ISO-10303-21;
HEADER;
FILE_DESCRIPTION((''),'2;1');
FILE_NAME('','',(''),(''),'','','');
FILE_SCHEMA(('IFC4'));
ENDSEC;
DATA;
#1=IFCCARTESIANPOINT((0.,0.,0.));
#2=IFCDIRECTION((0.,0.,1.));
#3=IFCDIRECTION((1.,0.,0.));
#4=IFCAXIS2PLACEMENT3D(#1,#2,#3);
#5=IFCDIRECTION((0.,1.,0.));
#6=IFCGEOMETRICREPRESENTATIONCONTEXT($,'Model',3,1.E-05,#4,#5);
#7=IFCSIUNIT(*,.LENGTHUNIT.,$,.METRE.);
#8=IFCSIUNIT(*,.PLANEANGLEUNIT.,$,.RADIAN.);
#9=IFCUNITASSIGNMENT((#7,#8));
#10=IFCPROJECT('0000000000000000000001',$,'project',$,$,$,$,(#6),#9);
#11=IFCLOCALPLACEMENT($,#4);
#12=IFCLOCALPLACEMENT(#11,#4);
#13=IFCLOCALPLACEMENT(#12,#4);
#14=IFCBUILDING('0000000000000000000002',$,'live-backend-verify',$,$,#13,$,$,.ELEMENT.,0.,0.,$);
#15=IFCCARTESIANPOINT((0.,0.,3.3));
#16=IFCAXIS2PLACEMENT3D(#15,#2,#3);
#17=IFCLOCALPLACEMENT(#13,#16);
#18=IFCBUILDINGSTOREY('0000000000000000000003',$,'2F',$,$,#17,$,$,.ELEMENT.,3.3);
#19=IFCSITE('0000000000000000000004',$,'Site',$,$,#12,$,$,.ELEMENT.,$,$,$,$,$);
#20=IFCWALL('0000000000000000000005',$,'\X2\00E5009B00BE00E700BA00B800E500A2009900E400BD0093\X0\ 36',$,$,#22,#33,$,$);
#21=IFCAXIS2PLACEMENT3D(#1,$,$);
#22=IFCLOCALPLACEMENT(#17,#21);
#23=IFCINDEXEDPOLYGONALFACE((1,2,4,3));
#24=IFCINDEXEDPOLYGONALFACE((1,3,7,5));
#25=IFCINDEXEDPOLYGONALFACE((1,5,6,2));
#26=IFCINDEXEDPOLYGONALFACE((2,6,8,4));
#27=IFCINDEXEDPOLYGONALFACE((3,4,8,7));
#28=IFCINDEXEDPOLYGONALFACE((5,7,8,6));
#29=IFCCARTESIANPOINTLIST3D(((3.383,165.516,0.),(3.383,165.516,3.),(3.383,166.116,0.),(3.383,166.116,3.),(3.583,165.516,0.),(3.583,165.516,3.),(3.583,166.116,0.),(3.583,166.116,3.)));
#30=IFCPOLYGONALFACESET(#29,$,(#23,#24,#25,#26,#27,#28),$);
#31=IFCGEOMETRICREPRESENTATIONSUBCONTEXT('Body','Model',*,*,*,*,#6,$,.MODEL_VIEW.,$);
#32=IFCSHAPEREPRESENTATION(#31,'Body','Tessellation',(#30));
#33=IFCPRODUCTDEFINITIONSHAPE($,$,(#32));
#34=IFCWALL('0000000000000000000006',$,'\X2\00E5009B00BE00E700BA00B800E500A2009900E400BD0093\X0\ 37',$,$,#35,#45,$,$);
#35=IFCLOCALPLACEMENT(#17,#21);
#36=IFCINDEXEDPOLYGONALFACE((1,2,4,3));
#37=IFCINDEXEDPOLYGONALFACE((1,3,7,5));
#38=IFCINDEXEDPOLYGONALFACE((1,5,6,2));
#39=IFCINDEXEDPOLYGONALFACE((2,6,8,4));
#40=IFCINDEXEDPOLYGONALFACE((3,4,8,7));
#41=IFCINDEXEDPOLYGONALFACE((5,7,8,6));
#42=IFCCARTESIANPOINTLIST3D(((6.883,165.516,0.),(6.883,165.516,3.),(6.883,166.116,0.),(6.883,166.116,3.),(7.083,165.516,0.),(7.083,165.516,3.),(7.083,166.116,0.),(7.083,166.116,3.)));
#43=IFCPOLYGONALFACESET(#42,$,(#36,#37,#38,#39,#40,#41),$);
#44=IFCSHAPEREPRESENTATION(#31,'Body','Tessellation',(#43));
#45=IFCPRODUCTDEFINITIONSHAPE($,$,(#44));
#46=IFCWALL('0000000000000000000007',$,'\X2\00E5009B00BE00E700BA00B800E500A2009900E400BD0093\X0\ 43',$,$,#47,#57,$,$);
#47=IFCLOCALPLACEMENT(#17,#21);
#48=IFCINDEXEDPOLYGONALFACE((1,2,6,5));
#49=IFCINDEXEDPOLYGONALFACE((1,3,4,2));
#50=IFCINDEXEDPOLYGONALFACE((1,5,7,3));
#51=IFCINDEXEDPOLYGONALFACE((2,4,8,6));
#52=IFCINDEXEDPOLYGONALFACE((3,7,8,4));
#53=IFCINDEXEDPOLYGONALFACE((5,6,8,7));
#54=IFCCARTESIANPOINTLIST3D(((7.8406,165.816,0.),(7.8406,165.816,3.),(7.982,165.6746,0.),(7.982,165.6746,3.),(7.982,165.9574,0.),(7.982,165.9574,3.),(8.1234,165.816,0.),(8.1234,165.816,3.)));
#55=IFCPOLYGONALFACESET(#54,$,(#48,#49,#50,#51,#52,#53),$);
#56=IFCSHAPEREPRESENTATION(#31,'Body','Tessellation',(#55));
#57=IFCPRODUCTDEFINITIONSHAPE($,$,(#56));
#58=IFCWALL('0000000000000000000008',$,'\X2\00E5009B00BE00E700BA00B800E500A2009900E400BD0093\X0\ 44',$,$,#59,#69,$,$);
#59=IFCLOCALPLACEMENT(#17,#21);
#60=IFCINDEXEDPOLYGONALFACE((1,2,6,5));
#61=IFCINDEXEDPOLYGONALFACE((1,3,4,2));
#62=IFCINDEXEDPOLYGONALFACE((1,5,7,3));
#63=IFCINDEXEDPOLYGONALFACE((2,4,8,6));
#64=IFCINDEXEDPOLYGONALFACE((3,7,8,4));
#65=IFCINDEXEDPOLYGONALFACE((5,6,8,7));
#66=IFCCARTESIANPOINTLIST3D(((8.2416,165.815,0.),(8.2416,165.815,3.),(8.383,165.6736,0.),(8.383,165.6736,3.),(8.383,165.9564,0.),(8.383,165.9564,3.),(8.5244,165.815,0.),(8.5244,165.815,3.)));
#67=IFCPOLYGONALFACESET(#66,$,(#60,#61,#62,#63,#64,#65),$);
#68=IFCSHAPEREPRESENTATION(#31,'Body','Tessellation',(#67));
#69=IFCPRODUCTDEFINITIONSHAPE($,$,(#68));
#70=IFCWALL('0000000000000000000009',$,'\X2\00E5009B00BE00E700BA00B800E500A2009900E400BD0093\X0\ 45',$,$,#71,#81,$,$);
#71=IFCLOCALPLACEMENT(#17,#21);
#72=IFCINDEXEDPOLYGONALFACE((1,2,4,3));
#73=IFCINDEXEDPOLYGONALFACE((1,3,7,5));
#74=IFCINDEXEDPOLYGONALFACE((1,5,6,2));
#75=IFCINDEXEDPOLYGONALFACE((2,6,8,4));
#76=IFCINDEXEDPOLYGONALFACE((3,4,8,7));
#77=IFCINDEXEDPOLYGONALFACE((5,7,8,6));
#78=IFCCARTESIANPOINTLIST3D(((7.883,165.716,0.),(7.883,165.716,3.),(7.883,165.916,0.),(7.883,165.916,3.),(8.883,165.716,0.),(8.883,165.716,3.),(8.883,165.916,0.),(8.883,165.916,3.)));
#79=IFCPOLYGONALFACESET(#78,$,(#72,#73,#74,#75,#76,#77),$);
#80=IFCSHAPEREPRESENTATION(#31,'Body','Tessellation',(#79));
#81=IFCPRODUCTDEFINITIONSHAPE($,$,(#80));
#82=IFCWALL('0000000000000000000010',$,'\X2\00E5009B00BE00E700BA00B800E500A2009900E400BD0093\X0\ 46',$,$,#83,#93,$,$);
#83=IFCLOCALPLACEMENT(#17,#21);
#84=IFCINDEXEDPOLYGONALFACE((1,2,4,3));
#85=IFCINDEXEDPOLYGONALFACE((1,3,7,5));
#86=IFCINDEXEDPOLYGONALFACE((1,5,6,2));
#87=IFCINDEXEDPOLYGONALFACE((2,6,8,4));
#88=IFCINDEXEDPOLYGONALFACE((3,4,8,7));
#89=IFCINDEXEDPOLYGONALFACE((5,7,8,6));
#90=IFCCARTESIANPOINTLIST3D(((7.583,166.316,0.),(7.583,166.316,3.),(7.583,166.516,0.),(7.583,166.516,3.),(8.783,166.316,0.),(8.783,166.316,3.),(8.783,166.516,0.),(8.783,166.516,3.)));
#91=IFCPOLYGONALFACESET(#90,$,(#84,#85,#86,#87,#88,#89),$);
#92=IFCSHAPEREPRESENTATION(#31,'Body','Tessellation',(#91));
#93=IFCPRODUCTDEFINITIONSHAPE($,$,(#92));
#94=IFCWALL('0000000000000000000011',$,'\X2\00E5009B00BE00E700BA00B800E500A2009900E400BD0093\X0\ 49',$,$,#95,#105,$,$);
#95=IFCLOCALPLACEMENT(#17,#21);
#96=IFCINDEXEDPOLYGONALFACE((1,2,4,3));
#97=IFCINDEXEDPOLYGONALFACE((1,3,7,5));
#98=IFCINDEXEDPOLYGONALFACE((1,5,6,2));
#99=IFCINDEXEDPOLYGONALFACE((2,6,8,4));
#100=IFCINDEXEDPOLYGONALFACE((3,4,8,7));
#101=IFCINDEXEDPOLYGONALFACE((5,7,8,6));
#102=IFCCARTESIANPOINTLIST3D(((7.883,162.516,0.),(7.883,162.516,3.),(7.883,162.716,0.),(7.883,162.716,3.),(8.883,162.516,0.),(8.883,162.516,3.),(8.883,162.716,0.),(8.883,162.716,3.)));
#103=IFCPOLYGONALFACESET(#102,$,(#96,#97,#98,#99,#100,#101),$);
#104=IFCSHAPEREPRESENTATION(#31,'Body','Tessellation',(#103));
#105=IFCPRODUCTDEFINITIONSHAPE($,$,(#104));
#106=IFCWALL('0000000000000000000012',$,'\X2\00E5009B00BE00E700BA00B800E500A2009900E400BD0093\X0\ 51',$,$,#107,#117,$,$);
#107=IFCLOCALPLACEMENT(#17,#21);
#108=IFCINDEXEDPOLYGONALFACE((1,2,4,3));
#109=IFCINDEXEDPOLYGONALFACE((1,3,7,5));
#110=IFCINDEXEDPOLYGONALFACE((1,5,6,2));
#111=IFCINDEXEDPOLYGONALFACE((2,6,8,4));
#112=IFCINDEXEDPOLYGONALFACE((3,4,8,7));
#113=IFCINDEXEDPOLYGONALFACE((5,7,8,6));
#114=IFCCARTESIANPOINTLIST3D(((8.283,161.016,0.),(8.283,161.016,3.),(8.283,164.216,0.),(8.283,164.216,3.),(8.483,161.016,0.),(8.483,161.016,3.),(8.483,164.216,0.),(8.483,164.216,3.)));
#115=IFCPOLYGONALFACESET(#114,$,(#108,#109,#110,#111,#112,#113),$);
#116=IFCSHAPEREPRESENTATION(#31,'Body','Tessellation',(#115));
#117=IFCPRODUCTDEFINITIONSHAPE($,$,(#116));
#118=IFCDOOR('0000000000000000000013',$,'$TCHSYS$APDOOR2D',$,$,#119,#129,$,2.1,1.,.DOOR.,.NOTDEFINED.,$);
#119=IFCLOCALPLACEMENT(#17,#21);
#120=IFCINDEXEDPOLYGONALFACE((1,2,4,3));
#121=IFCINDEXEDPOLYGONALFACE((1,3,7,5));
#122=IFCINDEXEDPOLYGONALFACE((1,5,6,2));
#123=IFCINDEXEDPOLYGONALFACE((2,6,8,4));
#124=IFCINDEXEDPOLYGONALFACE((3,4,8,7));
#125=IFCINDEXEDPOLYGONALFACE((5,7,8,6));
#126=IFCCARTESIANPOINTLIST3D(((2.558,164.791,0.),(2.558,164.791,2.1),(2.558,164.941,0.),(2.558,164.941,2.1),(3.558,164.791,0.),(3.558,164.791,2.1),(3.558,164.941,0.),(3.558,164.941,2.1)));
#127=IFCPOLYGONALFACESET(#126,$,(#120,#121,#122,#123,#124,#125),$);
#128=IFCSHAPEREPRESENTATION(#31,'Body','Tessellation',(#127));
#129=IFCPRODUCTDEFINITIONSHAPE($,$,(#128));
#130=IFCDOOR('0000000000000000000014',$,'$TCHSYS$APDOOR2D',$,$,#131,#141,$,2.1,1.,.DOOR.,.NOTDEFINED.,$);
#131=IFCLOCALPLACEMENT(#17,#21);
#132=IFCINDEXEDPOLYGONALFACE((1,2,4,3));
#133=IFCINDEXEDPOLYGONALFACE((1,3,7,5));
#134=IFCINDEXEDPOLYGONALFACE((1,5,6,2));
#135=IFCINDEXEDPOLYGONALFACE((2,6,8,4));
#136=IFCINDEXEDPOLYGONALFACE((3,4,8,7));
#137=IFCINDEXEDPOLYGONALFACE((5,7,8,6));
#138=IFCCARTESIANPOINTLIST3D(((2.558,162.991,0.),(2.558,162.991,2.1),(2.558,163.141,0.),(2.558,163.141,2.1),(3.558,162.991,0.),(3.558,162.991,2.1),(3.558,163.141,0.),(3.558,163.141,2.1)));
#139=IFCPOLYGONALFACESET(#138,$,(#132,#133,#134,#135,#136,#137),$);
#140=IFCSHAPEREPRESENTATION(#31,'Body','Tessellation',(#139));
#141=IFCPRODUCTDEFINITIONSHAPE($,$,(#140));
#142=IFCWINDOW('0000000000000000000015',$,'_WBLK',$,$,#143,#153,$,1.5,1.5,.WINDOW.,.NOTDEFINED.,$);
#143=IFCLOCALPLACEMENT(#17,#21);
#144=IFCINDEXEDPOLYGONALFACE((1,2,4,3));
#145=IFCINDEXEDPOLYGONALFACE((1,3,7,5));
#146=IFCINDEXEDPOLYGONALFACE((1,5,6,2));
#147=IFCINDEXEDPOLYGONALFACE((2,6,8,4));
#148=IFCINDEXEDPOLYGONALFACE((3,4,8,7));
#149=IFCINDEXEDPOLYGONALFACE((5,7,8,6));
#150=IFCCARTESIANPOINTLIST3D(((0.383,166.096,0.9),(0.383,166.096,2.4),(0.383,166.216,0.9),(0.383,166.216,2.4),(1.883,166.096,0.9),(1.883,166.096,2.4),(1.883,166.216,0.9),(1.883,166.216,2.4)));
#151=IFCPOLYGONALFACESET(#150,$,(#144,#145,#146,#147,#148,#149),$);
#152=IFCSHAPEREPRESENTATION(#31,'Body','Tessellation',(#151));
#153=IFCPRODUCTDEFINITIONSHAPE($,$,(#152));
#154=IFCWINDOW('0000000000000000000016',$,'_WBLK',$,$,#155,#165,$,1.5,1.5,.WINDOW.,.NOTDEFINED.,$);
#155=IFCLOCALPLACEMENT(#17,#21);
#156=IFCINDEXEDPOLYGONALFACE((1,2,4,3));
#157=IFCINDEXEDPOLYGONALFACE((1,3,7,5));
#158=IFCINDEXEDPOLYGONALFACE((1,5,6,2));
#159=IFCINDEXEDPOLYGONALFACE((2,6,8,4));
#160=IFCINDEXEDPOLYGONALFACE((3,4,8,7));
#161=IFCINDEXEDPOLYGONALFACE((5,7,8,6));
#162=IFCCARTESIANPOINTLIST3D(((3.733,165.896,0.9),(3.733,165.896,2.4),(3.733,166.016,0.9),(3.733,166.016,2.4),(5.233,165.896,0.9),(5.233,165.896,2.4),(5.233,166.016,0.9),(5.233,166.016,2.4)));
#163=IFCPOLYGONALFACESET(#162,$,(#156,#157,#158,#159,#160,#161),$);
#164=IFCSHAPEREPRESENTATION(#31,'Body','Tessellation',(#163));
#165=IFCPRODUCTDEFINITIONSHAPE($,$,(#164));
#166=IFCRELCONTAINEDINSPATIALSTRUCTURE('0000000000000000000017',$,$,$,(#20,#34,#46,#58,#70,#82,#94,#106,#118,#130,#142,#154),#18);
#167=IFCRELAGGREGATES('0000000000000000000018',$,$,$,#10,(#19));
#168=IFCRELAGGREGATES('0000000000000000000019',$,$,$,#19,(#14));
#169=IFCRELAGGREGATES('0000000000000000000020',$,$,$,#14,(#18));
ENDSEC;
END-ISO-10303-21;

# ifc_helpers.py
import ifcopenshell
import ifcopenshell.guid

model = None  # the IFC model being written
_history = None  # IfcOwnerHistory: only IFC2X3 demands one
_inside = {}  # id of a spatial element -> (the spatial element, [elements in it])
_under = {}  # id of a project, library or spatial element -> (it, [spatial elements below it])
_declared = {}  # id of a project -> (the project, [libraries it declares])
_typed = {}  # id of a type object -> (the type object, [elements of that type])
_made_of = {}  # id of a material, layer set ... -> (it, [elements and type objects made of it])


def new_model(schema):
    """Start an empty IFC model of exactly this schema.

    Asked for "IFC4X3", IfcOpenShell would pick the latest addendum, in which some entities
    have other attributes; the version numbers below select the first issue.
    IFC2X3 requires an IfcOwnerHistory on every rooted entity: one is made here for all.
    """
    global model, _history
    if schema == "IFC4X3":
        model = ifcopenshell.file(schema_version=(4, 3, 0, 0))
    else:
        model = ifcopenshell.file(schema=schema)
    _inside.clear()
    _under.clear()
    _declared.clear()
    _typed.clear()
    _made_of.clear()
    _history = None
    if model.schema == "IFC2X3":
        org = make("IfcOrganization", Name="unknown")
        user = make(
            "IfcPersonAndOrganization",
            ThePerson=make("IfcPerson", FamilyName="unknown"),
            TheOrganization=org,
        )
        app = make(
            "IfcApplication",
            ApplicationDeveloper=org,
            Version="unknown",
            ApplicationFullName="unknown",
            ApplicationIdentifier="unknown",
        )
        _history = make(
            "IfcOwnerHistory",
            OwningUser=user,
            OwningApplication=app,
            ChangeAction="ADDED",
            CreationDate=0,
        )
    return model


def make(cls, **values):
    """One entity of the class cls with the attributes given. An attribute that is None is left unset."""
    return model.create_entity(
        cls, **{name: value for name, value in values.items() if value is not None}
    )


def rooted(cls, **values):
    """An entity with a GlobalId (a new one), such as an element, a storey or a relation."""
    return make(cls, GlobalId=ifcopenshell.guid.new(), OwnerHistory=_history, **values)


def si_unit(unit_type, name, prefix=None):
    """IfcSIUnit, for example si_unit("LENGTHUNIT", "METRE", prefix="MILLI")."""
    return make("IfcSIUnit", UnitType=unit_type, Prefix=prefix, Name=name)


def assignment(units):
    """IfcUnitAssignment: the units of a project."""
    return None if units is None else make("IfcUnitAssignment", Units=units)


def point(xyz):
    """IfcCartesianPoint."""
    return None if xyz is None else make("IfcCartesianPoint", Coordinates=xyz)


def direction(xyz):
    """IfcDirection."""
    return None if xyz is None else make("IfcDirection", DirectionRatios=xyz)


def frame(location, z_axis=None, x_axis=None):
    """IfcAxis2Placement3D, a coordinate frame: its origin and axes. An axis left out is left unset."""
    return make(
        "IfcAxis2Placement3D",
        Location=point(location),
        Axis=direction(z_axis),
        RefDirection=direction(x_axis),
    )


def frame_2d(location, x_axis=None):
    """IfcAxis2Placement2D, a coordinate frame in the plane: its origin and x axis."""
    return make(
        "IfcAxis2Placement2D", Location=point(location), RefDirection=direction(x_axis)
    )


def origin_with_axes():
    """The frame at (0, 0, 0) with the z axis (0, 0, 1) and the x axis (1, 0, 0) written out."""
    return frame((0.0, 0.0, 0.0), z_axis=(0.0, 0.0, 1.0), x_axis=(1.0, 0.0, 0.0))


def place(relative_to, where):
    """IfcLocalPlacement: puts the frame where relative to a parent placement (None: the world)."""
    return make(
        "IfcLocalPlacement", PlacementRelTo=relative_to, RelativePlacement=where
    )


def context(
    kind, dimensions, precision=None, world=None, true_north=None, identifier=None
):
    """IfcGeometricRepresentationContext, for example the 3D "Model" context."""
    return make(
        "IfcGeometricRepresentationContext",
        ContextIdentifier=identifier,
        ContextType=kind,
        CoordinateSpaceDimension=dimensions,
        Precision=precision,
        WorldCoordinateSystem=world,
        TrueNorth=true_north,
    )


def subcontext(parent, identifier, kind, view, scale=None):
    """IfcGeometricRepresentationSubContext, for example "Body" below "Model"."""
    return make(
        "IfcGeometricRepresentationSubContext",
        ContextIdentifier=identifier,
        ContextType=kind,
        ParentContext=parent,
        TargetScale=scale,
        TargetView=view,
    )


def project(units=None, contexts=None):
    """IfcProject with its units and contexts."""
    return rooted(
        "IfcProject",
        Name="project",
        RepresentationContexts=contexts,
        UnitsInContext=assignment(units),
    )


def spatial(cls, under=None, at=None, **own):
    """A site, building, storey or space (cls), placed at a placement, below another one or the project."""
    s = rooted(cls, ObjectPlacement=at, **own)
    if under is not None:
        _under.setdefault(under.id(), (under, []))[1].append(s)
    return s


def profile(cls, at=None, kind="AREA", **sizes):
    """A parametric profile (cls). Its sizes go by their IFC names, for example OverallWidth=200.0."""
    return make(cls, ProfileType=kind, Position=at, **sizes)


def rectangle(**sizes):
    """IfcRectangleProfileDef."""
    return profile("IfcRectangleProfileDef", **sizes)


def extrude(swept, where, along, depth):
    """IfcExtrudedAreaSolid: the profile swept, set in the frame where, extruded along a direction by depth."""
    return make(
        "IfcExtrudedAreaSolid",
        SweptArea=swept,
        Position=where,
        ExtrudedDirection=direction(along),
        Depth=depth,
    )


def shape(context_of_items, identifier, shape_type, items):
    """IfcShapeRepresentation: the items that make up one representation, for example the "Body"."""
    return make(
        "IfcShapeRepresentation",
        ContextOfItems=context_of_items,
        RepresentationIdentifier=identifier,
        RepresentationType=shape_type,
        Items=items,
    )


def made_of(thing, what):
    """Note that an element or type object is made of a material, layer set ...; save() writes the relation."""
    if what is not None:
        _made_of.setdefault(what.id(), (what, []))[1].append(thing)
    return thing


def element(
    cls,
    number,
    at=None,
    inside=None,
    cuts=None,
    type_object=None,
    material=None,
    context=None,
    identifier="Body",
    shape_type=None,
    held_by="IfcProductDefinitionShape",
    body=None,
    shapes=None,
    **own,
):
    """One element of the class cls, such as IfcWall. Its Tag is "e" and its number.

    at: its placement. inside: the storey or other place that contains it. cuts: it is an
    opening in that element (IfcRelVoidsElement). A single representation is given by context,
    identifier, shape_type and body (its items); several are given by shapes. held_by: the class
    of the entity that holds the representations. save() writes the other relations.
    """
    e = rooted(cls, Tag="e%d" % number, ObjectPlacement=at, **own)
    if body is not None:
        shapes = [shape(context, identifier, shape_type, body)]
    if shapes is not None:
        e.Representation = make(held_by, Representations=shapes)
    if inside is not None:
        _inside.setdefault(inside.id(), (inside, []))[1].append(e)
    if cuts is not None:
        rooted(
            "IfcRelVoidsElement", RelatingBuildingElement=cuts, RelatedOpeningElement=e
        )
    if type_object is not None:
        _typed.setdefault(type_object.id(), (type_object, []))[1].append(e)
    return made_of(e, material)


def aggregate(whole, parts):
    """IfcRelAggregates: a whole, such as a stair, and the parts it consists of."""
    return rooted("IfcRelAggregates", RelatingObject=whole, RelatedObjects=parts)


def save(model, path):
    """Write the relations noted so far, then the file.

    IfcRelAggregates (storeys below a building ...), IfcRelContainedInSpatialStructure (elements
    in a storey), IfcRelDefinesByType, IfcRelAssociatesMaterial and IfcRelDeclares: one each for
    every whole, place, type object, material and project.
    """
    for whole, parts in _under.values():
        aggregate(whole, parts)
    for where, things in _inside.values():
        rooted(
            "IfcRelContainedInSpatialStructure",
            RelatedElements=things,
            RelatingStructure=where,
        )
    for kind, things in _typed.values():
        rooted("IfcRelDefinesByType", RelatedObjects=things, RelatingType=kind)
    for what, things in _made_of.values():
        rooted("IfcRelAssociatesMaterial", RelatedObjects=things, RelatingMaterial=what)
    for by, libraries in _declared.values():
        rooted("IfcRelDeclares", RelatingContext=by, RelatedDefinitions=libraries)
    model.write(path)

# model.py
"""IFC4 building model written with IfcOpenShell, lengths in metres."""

from ifc_helpers import new_model, si_unit, direction, frame, frame_2d, origin_with_axes, place, context, subcontext, project, spatial, rectangle, extrude, element, save


model = new_model("IFC4")

# Units and contexts
model_context = context("Model", 3, precision=1e-05, world=origin_with_axes(), true_north=direction((0.0, 1.0, 0.0)))
body_context = subcontext(model_context, "Body", "Model", "MODEL_VIEW")
ifc_project = project(units=[si_unit("LENGTHUNIT", "METRE"), si_unit("PLANEANGLEUNIT", "RADIAN")], contexts=[model_context])

# Site, building, storey
placement = place(None, origin_with_axes())
site_placement = place(placement, origin_with_axes())
site = spatial("IfcSite", under=ifc_project, at=site_placement, Name="Site", CompositionType="ELEMENT")
building_placement = place(site_placement, origin_with_axes())
building = spatial("IfcBuilding", under=site, at=building_placement, Name="live-backend-verify", CompositionType="ELEMENT", ElevationOfRefHeight=0.0, ElevationOfTerrain=0.0)
storey_placement = place(building_placement, frame((0.0, 0.0, 3.3), z_axis=(0.0, 0.0, 1.0), x_axis=(1.0, 0.0, 0.0)))
storey = spatial("IfcBuildingStorey", under=building, at=storey_placement, Name="2F", CompositionType="ELEMENT", Elevation=3.3)

# Walls
for number, where, z_axis, x_axis, name in (
    (1, (3.483, 165.816, 0.0), (0.0, 0.0, 1.0), (0.0, 1.0, 0.0), "å\u009b¾çº¸å¢\u0099ä½\u0093 36"),
    (2, (6.983, 165.816, 0.0), (0.0, 0.0, 1.0), (0.0, 1.0, 0.0), "å\u009b¾çº¸å¢\u0099ä½\u0093 37"),
):
    element("IfcWall", number, at=place(storey_placement, frame(where, z_axis=z_axis, x_axis=x_axis)), inside=storey, Name=name, context=body_context, shape_type="SweptSolid", body=[
        extrude(rectangle(XDim=0.6, YDim=0.2, at=frame_2d((0.0, 0.0), x_axis=(1.0, 0.0, 0.0))), frame((0.0, 0.0, 0.0), z_axis=(0.0, 0.0, 1.0)), (0.0, 0.0, 1.0), 3.0),
    ])
for number, where, z_axis, x_axis, name in (
    (3, (7.982, 165.816, 0.0), (0.0, 0.0, 1.0), (0.707107, -0.707107, 0.0), "å\u009b¾çº¸å¢\u0099ä½\u0093 43"),
    (4, (8.383, 165.815, 0.0), (0.0, 0.0, 1.0), (0.707107, 0.707107, 0.0), "å\u009b¾çº¸å¢\u0099ä½\u0093 44"),
):
    element("IfcWall", number, at=place(storey_placement, frame(where, z_axis=z_axis, x_axis=x_axis)), inside=storey, Name=name, context=body_context, shape_type="SweptSolid", body=[
        extrude(rectangle(XDim=0.2, YDim=0.2, at=frame_2d((0.0, 0.0), x_axis=(1.0, 0.0, 0.0))), frame((0.0, 0.0, 0.0), z_axis=(0.0, 0.0, 1.0)), (0.0, 0.0, 1.0), 3.0),
    ])
wall_1_placement = place(storey_placement, frame((8.383, 165.816, 0.0), z_axis=(0.0, 0.0, 1.0), x_axis=(1.0, 0.0, 0.0)))
element("IfcWall", 5, at=wall_1_placement, inside=storey, Name="å\u009b¾çº¸å¢\u0099ä½\u0093 45", context=body_context, shape_type="SweptSolid", body=[
    extrude(rectangle(XDim=1.0, YDim=0.2, at=frame_2d((0.0, 0.0), x_axis=(1.0, 0.0, 0.0))), frame((0.0, 0.0, 0.0), z_axis=(0.0, 0.0, 1.0)), (0.0, 0.0, 1.0), 3.0),
])
wall_2_placement = place(storey_placement, frame((8.183, 166.416, 0.0), z_axis=(0.0, 0.0, 1.0), x_axis=(1.0, 0.0, 0.0)))
element("IfcWall", 6, at=wall_2_placement, inside=storey, Name="å\u009b¾çº¸å¢\u0099ä½\u0093 46", context=body_context, shape_type="SweptSolid", body=[
    extrude(rectangle(XDim=1.2, YDim=0.2, at=frame_2d((0.0, 0.0), x_axis=(1.0, 0.0, 0.0))), frame((0.0, 0.0, 0.0), z_axis=(0.0, 0.0, 1.0)), (0.0, 0.0, 1.0), 3.0),
])
wall_3_placement = place(storey_placement, frame((8.383, 162.616, 0.0), z_axis=(0.0, 0.0, 1.0), x_axis=(1.0, 0.0, 0.0)))
element("IfcWall", 7, at=wall_3_placement, inside=storey, Name="å\u009b¾çº¸å¢\u0099ä½\u0093 49", context=body_context, shape_type="SweptSolid", body=[
    extrude(rectangle(XDim=1.0, YDim=0.2, at=frame_2d((0.0, 0.0), x_axis=(1.0, 0.0, 0.0))), frame((0.0, 0.0, 0.0), z_axis=(0.0, 0.0, 1.0)), (0.0, 0.0, 1.0), 3.0),
])
wall_4_placement = place(storey_placement, frame((8.383, 162.616, 0.0), z_axis=(0.0, 0.0, 1.0), x_axis=(0.0, 1.0, 0.0)))
element("IfcWall", 8, at=wall_4_placement, inside=storey, Name="å\u009b¾çº¸å¢\u0099ä½\u0093 51", context=body_context, shape_type="SweptSolid", body=[
    extrude(rectangle(XDim=3.2, YDim=0.2, at=frame_2d((0.0, 0.0), x_axis=(1.0, 0.0, 0.0))), frame((0.0, 0.0, 0.0), z_axis=(0.0, 0.0, 1.0)), (0.0, 0.0, 1.0), 3.0),
])

# Doors
for number, where, z_axis, x_axis, name in (
    (9, (3.058, 164.866, 0.0), (0.0, 0.0, 1.0), (1.0, 0.0, 0.0), "$TCHSYS$APDOOR2D"),
    (10, (3.058, 163.066, 0.0), (0.0, 0.0, 1.0), (1.0, 0.0, 0.0), "$TCHSYS$APDOOR2D"),
):
    element("IfcDoor", number, at=place(storey_placement, frame(where, z_axis=z_axis, x_axis=x_axis)), inside=storey, Name=name, OperationType="NOTDEFINED", OverallHeight=2.1, OverallWidth=1.0, PredefinedType="DOOR", context=body_context, shape_type="SweptSolid", body=[
        extrude(rectangle(XDim=1.0, YDim=0.15, at=frame_2d((0.0, 0.0), x_axis=(1.0, 0.0, 0.0))), frame((0.0, 0.0, 0.0), z_axis=(0.0, 0.0, 1.0)), (0.0, 0.0, 1.0), 2.1),
    ])

# Windows
for number, where, z_axis, x_axis, name in (
    (11, (1.133, 166.156, 0.9), (0.0, 0.0, 1.0), (1.0, 0.0, 0.0), "_WBLK"),
    (12, (4.483, 165.956, 0.9), (0.0, 0.0, 1.0), (1.0, 0.0, 0.0), "_WBLK"),
):
    element("IfcWindow", number, at=place(storey_placement, frame(where, z_axis=z_axis, x_axis=x_axis)), inside=storey, Name=name, OverallHeight=1.5, OverallWidth=1.5, PartitioningType="NOTDEFINED", PredefinedType="WINDOW", context=body_context, shape_type="SweptSolid", body=[
        extrude(rectangle(XDim=1.5, YDim=0.12, at=frame_2d((0.0, 0.0), x_axis=(1.0, 0.0, 0.0))), frame((0.0, 0.0, 0.0), z_axis=(0.0, 0.0, 1.0)), (0.0, 0.0, 1.0), 1.5),
    ])

save(model, "model.ifc")
